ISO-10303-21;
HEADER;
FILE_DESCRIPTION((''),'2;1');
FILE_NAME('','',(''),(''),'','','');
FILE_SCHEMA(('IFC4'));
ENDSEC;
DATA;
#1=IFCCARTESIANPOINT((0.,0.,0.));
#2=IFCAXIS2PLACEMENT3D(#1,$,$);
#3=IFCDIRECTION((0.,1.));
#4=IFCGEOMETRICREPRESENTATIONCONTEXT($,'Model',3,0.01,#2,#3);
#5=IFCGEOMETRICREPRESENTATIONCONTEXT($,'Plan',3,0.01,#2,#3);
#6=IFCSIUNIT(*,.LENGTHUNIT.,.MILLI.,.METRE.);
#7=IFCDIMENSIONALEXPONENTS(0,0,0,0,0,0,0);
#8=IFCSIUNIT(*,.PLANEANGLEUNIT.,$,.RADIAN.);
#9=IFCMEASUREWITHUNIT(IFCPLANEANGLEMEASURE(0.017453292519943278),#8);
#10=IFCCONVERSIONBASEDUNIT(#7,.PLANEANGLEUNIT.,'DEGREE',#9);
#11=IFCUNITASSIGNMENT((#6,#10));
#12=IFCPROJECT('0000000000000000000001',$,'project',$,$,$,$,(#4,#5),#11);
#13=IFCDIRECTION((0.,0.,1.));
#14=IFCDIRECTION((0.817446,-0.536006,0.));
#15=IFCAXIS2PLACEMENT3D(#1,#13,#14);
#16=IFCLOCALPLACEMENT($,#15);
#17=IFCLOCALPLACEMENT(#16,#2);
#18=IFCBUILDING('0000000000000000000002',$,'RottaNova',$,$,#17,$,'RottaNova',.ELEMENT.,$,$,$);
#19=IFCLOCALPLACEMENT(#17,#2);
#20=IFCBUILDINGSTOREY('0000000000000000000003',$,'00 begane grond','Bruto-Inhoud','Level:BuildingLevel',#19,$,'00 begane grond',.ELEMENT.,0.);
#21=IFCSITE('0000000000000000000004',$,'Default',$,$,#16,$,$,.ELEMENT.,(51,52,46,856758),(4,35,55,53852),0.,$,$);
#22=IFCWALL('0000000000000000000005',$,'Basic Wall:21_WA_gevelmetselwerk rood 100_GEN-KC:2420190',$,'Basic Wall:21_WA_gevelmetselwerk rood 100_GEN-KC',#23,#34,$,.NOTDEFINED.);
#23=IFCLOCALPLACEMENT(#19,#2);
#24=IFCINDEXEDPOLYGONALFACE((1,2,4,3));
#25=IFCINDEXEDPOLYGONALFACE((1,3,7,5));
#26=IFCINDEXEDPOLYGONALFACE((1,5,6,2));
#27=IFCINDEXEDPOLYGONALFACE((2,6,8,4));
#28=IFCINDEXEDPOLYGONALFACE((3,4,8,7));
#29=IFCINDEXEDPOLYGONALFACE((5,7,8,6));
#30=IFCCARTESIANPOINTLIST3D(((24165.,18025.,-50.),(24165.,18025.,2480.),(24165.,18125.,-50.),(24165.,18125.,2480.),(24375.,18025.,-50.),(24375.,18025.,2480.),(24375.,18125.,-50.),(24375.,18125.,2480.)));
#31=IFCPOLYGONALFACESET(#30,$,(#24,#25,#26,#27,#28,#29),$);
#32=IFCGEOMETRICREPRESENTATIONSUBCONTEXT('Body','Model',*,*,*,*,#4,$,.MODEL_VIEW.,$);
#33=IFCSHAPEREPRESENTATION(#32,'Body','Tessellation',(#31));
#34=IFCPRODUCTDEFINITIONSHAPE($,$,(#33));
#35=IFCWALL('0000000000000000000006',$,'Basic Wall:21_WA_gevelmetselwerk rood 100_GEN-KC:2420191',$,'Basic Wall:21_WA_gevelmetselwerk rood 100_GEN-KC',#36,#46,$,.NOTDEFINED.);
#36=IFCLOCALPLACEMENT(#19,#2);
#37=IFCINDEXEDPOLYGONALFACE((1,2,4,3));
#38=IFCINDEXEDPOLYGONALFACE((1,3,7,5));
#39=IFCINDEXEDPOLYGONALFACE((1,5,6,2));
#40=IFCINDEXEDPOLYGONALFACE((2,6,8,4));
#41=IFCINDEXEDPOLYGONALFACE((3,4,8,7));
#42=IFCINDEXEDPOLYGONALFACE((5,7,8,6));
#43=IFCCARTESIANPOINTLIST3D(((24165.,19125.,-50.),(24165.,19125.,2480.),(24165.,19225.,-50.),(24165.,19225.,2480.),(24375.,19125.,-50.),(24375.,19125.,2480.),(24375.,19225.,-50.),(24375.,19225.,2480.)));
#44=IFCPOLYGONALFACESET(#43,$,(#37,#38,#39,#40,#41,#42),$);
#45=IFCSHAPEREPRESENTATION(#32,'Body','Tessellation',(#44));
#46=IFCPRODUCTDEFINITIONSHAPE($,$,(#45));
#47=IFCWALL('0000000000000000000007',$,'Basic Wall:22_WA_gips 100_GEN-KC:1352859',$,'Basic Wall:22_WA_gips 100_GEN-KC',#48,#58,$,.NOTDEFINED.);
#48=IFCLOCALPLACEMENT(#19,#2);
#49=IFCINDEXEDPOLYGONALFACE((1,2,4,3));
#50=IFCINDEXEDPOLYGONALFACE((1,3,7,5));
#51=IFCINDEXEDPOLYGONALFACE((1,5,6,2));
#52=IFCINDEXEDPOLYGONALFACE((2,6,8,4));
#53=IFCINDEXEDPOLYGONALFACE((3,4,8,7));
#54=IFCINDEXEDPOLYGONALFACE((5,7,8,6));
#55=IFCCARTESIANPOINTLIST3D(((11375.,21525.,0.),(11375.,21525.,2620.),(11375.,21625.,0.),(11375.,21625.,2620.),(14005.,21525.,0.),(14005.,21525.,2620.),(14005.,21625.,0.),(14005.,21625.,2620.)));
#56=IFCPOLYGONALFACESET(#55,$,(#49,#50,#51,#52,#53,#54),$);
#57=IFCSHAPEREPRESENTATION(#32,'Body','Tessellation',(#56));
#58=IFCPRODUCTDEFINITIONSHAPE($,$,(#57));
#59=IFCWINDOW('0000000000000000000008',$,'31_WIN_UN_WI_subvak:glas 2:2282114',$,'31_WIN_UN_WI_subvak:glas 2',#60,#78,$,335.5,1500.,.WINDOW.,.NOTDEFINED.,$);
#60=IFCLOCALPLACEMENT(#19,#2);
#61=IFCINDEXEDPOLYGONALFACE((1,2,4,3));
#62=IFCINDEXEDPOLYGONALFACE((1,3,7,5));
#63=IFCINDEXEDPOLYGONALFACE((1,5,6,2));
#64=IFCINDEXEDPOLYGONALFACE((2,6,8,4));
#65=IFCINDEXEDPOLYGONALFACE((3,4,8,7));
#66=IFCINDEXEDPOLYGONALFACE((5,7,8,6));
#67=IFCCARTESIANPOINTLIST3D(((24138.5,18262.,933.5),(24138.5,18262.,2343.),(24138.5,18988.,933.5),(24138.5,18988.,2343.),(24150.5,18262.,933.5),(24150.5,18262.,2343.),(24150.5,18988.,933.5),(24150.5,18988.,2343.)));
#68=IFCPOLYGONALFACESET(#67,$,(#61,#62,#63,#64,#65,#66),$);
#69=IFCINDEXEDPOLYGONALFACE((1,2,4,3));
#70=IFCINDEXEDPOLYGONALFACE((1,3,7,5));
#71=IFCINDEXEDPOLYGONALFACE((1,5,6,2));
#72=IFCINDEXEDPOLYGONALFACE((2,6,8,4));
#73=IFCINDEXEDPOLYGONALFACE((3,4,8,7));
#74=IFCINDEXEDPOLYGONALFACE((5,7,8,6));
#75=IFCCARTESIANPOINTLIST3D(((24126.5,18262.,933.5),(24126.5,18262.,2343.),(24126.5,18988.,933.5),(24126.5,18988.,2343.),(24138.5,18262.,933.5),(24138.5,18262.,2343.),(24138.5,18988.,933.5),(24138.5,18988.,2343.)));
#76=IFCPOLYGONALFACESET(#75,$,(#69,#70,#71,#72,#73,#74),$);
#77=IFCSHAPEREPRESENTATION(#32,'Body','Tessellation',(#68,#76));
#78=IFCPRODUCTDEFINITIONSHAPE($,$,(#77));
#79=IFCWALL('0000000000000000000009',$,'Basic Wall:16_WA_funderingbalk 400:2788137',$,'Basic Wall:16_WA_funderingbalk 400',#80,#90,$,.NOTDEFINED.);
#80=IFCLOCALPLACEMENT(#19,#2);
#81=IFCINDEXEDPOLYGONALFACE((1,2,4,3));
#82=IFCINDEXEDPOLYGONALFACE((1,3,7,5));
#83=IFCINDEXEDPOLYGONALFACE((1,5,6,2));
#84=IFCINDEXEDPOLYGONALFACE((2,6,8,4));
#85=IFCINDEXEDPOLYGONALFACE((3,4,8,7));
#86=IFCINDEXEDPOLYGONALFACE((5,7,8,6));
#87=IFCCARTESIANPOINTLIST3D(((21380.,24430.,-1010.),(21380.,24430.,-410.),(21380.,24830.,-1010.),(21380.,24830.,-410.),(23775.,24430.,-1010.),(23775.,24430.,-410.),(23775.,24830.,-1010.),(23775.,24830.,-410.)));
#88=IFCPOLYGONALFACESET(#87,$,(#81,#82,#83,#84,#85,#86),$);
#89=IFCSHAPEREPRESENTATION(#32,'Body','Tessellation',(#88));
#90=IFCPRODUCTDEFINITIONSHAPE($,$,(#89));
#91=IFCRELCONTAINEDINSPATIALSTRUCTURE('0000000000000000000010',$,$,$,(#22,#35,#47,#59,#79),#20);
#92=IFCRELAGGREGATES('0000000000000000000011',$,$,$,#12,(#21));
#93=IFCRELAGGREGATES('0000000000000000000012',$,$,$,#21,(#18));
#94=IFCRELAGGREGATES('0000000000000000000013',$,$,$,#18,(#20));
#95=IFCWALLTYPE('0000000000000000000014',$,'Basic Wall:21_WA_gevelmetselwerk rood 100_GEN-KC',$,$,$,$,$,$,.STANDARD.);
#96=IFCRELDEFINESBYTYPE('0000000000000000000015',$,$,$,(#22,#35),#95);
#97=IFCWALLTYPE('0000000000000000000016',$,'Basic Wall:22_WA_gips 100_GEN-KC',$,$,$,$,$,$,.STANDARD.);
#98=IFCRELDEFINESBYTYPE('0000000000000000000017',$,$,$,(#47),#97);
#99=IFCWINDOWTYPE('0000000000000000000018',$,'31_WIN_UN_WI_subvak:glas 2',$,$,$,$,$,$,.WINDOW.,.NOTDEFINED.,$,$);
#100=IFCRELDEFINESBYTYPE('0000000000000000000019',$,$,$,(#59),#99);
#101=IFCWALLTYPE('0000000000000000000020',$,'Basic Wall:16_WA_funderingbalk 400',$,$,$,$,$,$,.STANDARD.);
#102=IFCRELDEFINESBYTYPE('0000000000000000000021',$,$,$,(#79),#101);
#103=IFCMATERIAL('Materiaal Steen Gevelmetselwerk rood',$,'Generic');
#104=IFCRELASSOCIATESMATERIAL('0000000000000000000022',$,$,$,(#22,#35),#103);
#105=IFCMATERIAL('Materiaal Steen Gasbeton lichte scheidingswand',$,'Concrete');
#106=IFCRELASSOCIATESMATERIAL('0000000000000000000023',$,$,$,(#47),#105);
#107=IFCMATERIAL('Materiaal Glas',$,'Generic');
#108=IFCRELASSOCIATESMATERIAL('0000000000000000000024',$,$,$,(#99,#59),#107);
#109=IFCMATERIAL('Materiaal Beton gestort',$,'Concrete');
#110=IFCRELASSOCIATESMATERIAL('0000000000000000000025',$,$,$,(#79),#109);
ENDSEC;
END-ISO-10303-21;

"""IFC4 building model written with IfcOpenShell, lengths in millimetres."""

from ifc_helpers import new_model, entity, si_unit, converted_unit, direction, frame, origin, place, context, subcontext, project, spatial, indexed_curve, outline, extrude, source, transform, mapped, material, type_object, type_shapes, element, save


model = new_model("IFC4")

# Units and contexts
model_context = context("Model", 3, precision=0.01, world=origin(), true_north=direction((0.0, 1.0)))
plan_context = context("Plan", 3, precision=0.01, world=origin(), true_north=direction((0.0, 1.0)))
body_context = subcontext(model_context, "Body", "Model", "MODEL_VIEW")
ifc_project = project(units=[si_unit("LENGTHUNIT", "METRE", prefix="MILLI"), converted_unit("PLANEANGLEUNIT", "DEGREE", entity("IfcPlaneAngleMeasure", 0.017453292519943278), si_unit("PLANEANGLEUNIT", "RADIAN"), dimensions=[0, 0, 0, 0, 0, 0, 0])], contexts=[model_context, plan_context])

# Site, building, storey
site_placement = place(None, frame((0.0, 0.0, 0.0), z_axis=(0.0, 0.0, 1.0), x_axis=(0.817446, -0.536006, 0.0)))
site = spatial("IfcSite", under=ifc_project, at=site_placement, Name="Default", CompositionType="ELEMENT", RefLatitude=(51, 52, 46, 856758), RefLongitude=(4, 35, 55, 53852), RefElevation=0.0)
building_placement = place(site_placement, origin())
building = spatial("IfcBuilding", under=site, at=building_placement, Name="RottaNova", LongName="RottaNova", CompositionType="ELEMENT")
storey_placement = place(building_placement, origin())
storey = spatial("IfcBuildingStorey", under=building, at=storey_placement, Name="00 begane grond", Description="Bruto-Inhoud", ObjectType="Level:BuildingLevel", LongName="00 begane grond", CompositionType="ELEMENT", Elevation=0.0)

# Shared definitions
ifc_material_1 = material(Name="Materiaal Glas", Category="Generic")

# Walls
ifc_material_2 = material(Name="Materiaal Steen Gevelmetselwerk rood", Category="Generic")
wall_type_1 = type_object("IfcWallType", Name="Basic Wall:21_WA_gevelmetselwerk rood 100_GEN-KC", PredefinedType="STANDARD")
wall_1_placement = place(storey_placement, frame((24375.0, 18075.0, -50.0), z_axis=(0.0, 0.0, 1.0), x_axis=(-1.0, 0.0, 0.0)))
element("IfcWall", 1, at=wall_1_placement, inside=storey, type_object=wall_type_1, material=ifc_material_2, Name="Basic Wall:21_WA_gevelmetselwerk rood 100_GEN-KC:2420190", ObjectType="Basic Wall:21_WA_gevelmetselwerk rood 100_GEN-KC", PredefinedType="NOTDEFINED", context=body_context, shape_type="SweptSolid", body=[
    extrude(outline(indexed_curve([(210.0, 50.0), (0.0, 50.0), (0.0, -50.0), (210.0, -50.0), (210.0, 50.0)], self_intersect=False)), origin(), (0.0, 0.0, 1.0), 2530.0),
])
wall_2_placement = place(storey_placement, frame((24375.0, 19175.0, -50.0), z_axis=(0.0, 0.0, 1.0), x_axis=(-1.0, 0.0, 0.0)))
element("IfcWall", 2, at=wall_2_placement, inside=storey, type_object=wall_type_1, material=ifc_material_2, Name="Basic Wall:21_WA_gevelmetselwerk rood 100_GEN-KC:2420191", ObjectType="Basic Wall:21_WA_gevelmetselwerk rood 100_GEN-KC", PredefinedType="NOTDEFINED", context=body_context, shape_type="SweptSolid", body=[
    extrude(outline(indexed_curve([(210.0, 50.0), (0.0, 50.0), (0.0, -50.0), (210.0, -50.0), (210.0, 50.0)], self_intersect=False)), origin(), (0.0, 0.0, 1.0), 2530.0),
])
ifc_material_3 = material(Name="Materiaal Steen Gasbeton lichte scheidingswand", Category="Concrete")
wall_type_2 = type_object("IfcWallType", Name="Basic Wall:22_WA_gips 100_GEN-KC", PredefinedType="STANDARD")
wall_3_placement = place(storey_placement, frame((14005.0, 21575.0, 0.0), z_axis=(0.0, 0.0, 1.0), x_axis=(-1.0, 0.0, 0.0)))
element("IfcWall", 3, at=wall_3_placement, inside=storey, type_object=wall_type_2, material=ifc_material_3, Name="Basic Wall:22_WA_gips 100_GEN-KC:1352859", ObjectType="Basic Wall:22_WA_gips 100_GEN-KC", PredefinedType="NOTDEFINED", context=body_context, shape_type="SweptSolid", body=[
    extrude(outline(indexed_curve([(2630.0, 50.0), (0.0, 50.0), (0.0, -50.0), (2630.0, -50.0), (2630.0, 50.0)], self_intersect=False)), origin(), (0.0, 0.0, 1.0), 2620.0),
])

# Window
window_type = type_object("IfcWindowType", Name="31_WIN_UN_WI_subvak:glas 2", PartitioningType="NOTDEFINED", PredefinedType="WINDOW", material=ifc_material_1)
shared_shape_1 = source(origin(), body_context, "Body", "SweptSolid", [
    extrude(outline(indexed_curve([(-363.0, -6.0), (363.0, -6.0), (363.0, 6.0), (-363.0, 6.0), (-363.0, -6.0)], self_intersect=False)), frame((0.0, -6.0, 0.0)), (0.0, 0.0, 1.0), 1409.5),
    extrude(outline(indexed_curve([(-363.0, -6.0), (363.0, -6.0), (363.0, 6.0), (-363.0, 6.0), (-363.0, -6.0)], self_intersect=False)), frame((0.0, 6.0, 0.0)), (0.0, 0.0, 1.0), 1409.5),
])
type_shapes(window_type, [shared_shape_1])
window_1_placement = place(storey_placement, frame((24138.5, 18625.0, 933.5), z_axis=(0.0, 0.0, 1.0), x_axis=(0.0, 1.0, 0.0)))
element("IfcWindow", 4, at=window_1_placement, inside=storey, type_object=window_type, material=ifc_material_1, Name="31_WIN_UN_WI_subvak:glas 2:2282114", ObjectType="31_WIN_UN_WI_subvak:glas 2", OverallHeight=335.5, OverallWidth=1500.0, PartitioningType="NOTDEFINED", PredefinedType="WINDOW", context=body_context, shape_type="MappedRepresentation", body=[
    mapped(shared_shape_1, transform((0.0, 0.0, 0.0), scale=1.0)),
])

# Wall
ifc_material_4 = material(Name="Materiaal Beton gestort", Category="Concrete")
wall_type_3 = type_object("IfcWallType", Name="Basic Wall:16_WA_funderingbalk 400", PredefinedType="STANDARD")
wall_4_placement = place(storey_placement, frame((21380.0, 24630.0, -1010.0)))
element("IfcWall", 5, at=wall_4_placement, inside=storey, type_object=wall_type_3, material=ifc_material_4, Name="Basic Wall:16_WA_funderingbalk 400:2788137", ObjectType="Basic Wall:16_WA_funderingbalk 400", PredefinedType="NOTDEFINED", context=body_context, shape_type="SweptSolid", body=[
    extrude(outline(indexed_curve([(2395.0, 200.0), (0.0, 200.0), (0.0, -200.0), (2395.0, -200.0), (2395.0, 200.0)], self_intersect=False)), origin(), (0.0, 0.0, 1.0), 600.0),
])

save(model, "model.ifc")
